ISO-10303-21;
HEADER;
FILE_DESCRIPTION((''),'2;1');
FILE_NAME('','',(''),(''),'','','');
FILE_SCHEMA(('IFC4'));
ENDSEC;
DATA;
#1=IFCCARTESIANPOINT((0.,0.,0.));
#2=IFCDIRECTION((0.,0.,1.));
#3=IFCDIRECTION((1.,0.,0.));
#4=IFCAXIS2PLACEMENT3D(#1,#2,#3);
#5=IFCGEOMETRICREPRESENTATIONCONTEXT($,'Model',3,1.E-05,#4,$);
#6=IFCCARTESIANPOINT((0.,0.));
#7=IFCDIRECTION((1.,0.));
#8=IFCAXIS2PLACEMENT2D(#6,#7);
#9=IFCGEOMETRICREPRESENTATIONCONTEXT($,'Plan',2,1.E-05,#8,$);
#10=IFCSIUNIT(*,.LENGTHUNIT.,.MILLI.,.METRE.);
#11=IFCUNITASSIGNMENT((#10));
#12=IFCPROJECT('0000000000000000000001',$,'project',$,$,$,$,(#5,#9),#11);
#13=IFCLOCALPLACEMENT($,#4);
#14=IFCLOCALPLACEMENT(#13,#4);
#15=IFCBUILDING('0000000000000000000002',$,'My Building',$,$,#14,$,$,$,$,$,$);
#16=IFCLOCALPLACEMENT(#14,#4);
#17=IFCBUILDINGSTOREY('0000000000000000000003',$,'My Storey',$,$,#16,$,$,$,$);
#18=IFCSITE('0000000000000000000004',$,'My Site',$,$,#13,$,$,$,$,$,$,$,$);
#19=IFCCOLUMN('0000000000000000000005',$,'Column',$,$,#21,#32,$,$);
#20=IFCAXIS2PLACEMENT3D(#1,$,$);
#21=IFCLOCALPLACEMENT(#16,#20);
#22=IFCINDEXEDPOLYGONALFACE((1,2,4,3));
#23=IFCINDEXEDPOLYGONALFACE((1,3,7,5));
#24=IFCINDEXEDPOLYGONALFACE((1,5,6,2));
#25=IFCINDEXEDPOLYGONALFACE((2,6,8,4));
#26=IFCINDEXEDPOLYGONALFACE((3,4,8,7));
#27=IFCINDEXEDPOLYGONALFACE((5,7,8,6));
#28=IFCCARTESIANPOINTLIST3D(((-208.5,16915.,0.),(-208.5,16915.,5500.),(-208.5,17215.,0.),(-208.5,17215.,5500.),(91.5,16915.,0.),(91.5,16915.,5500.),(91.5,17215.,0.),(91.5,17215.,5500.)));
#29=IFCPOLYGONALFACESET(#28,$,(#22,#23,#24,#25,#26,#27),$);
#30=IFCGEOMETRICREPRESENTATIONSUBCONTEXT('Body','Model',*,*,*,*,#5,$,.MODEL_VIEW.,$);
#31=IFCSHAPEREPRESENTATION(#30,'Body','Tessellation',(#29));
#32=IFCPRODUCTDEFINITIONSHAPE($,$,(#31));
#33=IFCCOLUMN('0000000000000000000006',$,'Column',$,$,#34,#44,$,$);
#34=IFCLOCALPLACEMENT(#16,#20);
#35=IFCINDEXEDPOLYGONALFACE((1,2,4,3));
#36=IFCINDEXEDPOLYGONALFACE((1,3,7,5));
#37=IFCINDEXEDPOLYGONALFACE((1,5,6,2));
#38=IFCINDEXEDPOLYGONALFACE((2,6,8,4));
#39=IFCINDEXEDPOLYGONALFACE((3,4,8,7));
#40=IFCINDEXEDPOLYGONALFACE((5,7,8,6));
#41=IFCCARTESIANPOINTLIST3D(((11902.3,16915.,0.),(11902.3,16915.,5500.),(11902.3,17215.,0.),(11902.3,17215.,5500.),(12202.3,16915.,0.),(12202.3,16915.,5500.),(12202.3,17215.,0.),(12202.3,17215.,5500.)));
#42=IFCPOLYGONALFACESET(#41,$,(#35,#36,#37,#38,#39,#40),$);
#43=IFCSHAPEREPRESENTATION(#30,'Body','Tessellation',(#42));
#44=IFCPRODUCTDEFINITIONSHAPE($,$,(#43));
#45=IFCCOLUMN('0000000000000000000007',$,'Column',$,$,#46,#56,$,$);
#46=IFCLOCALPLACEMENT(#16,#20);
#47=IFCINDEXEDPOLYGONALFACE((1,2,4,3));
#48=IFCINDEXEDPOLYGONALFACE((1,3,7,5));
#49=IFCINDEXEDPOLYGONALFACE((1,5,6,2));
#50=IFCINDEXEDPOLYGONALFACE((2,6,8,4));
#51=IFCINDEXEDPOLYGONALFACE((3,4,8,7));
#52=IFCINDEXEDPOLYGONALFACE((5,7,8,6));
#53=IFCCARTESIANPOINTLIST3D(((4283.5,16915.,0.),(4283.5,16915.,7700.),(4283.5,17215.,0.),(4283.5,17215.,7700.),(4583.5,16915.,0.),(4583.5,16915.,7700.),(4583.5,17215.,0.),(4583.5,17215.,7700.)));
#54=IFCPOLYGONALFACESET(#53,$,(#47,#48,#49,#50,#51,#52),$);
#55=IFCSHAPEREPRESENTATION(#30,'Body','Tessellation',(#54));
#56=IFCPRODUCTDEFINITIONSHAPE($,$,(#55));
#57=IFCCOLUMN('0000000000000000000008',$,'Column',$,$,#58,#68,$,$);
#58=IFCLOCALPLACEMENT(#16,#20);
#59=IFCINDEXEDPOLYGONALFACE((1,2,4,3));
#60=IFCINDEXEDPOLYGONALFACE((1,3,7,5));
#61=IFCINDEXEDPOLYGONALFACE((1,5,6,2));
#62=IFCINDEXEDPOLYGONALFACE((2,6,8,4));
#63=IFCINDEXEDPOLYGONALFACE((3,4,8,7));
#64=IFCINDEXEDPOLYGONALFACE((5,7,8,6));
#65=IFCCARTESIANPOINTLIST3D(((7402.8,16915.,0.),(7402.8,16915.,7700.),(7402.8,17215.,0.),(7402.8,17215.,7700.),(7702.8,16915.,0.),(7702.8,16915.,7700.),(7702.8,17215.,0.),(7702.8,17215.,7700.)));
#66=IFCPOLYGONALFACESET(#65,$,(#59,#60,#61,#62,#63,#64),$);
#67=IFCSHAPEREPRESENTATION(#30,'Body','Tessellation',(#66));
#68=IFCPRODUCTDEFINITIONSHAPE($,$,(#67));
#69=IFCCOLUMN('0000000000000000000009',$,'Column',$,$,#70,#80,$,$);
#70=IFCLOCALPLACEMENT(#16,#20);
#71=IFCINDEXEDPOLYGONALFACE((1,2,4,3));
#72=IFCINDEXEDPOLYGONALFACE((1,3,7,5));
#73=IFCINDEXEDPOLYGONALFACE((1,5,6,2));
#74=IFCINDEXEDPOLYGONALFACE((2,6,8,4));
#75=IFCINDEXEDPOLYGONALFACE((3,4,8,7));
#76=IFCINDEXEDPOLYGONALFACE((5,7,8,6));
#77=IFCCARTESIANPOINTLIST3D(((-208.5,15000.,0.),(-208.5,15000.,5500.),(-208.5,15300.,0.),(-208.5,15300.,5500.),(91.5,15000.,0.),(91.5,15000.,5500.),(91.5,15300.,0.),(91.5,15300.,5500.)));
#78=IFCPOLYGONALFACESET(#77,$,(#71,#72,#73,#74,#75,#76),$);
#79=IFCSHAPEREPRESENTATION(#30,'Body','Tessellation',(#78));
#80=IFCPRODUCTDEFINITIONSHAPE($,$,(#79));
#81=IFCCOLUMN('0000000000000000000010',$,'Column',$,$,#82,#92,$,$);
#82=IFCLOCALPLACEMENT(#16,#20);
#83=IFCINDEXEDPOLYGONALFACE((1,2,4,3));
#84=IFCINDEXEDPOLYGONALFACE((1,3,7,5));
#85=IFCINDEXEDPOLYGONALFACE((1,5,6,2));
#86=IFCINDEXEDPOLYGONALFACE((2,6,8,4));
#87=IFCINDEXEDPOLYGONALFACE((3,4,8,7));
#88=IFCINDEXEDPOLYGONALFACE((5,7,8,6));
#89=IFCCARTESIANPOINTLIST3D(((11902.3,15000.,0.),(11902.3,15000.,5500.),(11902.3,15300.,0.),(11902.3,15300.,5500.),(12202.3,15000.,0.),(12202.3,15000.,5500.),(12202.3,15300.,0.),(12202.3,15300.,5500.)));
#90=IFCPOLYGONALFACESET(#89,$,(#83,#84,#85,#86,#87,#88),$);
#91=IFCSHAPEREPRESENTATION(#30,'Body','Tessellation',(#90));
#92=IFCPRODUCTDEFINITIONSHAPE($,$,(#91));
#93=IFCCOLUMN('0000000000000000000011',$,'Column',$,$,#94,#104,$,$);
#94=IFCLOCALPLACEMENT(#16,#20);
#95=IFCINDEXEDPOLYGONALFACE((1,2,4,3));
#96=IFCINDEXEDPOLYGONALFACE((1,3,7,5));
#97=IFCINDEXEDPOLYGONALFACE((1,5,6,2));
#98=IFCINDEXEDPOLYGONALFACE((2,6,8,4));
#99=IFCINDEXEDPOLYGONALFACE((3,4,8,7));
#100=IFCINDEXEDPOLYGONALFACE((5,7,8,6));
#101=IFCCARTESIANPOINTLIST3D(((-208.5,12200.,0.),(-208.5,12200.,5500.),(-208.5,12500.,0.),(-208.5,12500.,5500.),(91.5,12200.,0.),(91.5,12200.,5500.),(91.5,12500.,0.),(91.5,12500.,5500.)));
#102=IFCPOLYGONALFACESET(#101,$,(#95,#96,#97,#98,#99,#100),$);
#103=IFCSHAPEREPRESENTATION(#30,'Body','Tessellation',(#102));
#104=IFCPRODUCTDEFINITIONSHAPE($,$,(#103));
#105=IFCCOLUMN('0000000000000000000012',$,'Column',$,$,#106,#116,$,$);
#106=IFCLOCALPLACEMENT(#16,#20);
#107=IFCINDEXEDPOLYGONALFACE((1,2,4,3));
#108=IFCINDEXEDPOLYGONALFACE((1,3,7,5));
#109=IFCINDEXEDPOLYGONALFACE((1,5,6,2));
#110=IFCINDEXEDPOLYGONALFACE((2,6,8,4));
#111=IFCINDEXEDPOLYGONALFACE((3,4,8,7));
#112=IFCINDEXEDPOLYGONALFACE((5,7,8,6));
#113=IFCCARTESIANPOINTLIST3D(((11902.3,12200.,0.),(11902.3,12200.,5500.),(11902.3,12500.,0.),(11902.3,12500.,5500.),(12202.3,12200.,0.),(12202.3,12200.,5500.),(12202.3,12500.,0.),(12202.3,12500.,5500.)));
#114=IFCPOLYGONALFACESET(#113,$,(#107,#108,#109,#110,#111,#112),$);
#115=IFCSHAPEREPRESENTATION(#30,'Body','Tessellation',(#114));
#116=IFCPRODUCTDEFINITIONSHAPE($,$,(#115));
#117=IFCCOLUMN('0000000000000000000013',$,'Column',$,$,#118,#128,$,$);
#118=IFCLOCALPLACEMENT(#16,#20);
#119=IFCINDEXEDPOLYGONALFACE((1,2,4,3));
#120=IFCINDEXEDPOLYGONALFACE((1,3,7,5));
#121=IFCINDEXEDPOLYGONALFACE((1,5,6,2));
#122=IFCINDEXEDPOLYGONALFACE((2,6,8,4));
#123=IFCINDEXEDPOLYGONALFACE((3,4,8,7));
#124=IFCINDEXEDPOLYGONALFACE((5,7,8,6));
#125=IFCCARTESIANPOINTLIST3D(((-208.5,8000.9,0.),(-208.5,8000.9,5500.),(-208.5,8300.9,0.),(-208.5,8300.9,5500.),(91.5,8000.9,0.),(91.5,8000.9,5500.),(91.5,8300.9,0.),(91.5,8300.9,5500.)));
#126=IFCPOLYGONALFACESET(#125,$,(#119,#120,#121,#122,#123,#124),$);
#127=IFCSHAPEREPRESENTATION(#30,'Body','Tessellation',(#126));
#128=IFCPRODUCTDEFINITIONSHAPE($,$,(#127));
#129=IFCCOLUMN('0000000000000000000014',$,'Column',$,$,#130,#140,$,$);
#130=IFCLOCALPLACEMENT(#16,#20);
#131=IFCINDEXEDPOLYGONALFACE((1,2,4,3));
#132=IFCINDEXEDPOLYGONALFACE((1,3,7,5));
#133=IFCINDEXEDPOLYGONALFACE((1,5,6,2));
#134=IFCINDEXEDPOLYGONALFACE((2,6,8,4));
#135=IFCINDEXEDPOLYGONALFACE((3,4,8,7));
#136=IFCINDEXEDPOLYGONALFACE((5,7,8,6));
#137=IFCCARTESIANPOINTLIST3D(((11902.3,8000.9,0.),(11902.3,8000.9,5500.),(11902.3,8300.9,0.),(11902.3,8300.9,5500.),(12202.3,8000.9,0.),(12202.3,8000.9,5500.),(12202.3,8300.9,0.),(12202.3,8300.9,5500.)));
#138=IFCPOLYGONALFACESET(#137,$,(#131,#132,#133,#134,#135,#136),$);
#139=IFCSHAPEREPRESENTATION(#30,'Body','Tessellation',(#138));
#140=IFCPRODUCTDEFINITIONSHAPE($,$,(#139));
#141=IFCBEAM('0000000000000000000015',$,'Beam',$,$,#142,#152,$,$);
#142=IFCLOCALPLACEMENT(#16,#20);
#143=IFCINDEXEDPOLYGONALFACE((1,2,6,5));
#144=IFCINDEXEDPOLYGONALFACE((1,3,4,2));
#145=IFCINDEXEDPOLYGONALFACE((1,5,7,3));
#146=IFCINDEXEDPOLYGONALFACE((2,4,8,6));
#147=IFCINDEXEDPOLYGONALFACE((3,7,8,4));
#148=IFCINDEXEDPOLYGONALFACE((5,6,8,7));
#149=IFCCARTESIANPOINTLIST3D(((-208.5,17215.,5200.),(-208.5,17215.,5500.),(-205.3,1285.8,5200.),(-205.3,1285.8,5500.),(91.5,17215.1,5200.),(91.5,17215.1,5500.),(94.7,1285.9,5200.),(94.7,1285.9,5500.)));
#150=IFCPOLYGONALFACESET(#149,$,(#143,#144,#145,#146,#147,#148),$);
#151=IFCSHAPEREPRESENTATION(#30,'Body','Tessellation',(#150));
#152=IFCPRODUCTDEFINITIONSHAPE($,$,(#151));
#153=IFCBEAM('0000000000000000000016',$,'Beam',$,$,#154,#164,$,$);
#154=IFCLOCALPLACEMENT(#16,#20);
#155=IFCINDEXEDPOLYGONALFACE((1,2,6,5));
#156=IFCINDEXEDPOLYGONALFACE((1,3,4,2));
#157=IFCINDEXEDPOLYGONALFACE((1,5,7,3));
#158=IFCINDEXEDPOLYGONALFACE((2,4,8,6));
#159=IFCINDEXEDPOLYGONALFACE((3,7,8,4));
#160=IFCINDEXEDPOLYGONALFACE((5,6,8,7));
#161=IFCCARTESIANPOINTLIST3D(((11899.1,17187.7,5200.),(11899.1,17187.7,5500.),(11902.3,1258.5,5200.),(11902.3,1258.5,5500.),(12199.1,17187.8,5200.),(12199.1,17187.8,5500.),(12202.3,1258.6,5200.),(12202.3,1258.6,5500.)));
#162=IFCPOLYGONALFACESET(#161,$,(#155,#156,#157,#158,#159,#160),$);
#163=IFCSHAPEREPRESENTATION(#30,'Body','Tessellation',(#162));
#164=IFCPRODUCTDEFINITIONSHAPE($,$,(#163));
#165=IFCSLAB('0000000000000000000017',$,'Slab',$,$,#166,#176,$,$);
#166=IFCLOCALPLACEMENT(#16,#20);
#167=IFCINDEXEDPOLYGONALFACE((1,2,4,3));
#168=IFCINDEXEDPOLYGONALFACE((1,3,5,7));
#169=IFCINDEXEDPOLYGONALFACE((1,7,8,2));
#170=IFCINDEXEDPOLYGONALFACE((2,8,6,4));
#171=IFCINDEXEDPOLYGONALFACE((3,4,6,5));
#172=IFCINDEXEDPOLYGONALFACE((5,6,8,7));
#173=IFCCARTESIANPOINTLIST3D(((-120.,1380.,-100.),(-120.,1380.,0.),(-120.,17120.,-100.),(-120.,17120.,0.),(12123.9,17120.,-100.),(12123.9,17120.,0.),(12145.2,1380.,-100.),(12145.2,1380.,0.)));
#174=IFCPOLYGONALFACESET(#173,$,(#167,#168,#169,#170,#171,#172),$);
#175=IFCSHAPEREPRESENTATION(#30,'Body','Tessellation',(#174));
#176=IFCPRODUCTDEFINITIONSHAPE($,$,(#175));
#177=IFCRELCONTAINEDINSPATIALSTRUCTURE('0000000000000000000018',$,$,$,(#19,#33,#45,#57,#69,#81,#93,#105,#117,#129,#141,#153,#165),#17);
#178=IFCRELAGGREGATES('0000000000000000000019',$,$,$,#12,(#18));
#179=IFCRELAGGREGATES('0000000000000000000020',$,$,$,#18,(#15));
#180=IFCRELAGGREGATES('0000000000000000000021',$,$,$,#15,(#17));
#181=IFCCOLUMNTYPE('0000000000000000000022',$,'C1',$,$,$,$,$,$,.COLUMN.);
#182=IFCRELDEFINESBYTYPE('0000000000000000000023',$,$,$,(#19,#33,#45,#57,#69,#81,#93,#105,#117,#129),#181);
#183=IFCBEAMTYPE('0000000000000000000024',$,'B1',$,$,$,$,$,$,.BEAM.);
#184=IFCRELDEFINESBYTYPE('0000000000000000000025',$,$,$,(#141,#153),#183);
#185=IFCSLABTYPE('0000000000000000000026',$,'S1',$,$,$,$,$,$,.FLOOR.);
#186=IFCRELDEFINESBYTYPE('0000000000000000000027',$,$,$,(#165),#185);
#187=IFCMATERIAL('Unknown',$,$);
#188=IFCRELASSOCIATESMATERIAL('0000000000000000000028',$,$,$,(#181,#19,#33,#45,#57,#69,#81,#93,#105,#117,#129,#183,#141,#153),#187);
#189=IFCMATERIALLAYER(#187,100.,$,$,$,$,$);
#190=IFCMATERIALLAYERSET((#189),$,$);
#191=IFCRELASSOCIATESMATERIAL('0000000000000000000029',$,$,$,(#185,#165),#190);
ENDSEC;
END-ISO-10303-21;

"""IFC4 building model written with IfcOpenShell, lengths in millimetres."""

from ifc_helpers import new_model, si_unit, frame, origin_with_axes, origin_2d_with_axis, place, context, subcontext, project, spatial, indexed_curve, rectangle, outline, extrude, material, layer, layer_set, layer_usage, material_profile, profile_set, profile_usage, type_object, element, save


model = new_model("IFC4")

# Units and contexts
model_context = context("Model", 3, precision=1e-05, world=origin_with_axes())
plan_context = context("Plan", 2, precision=1e-05, world=origin_2d_with_axis())
body_context_1 = subcontext(model_context, "Body", "Model", "MODEL_VIEW")
ifc_project = project(units=[si_unit("LENGTHUNIT", "METRE", prefix="MILLI")], contexts=[model_context, plan_context])

# Site, building, storey
site_placement = place(None, origin_with_axes())
site = spatial("IfcSite", under=ifc_project, at=site_placement, Name="My Site")
building_placement = place(site_placement, origin_with_axes())
building = spatial("IfcBuilding", under=site, at=building_placement, Name="My Building")
storey_placement = place(building_placement, origin_with_axes())
storey = spatial("IfcBuildingStorey", under=building, at=storey_placement, Name="My Storey")

# Columns
ifc_material = material(Name="Unknown")
ifc_material_profile_1 = material_profile(ifc_material, rectangle(XDim=300.0, YDim=300.0))
ifc_profile_set_1 = profile_set([ifc_material_profile_1])
ifc_profile_usage_1 = profile_usage(ifc_profile_set_1, cardinal=5)
column_type = type_object("IfcColumnType", Name="C1", PredefinedType="COLUMN", material=ifc_profile_set_1)
column_1_placement = place(storey_placement, frame((-58.5, 17065.0, 0.0), z_axis=(0.0, 0.0, 1.0), x_axis=(1.0, 0.0, 0.0)))
element("IfcColumn", 1, at=column_1_placement, inside=storey, type_object=column_type, material=ifc_profile_usage_1, Name="Column", context=body_context_1, shape_type="SweptSolid", body=[
    extrude(rectangle(XDim=300.0, YDim=300.0), origin_with_axes(), (0.0, 0.0, 1.0), 5500.0),
])
ifc_profile_usage_2 = profile_usage(ifc_profile_set_1, cardinal=5)
column_2_placement = place(storey_placement, frame((12052.3, 17065.0, 0.0), z_axis=(0.0, 0.0, 1.0), x_axis=(1.0, 0.0, 0.0)))
element("IfcColumn", 2, at=column_2_placement, inside=storey, type_object=column_type, material=ifc_profile_usage_2, Name="Column", context=body_context_1, shape_type="SweptSolid", body=[
    extrude(rectangle(XDim=300.0, YDim=300.0), origin_with_axes(), (0.0, 0.0, 1.0), 5500.0),
])
ifc_profile_usage_3 = profile_usage(ifc_profile_set_1, cardinal=5)
column_3_placement = place(storey_placement, frame((4433.5, 17065.0, 0.0), z_axis=(0.0, 0.0, 1.0), x_axis=(1.0, 0.0, 0.0)))
element("IfcColumn", 3, at=column_3_placement, inside=storey, type_object=column_type, material=ifc_profile_usage_3, Name="Column", context=body_context_1, shape_type="SweptSolid", body=[
    extrude(rectangle(XDim=300.0, YDim=300.0), origin_with_axes(), (0.0, 0.0, 1.0), 7700.0),
])
ifc_profile_usage_4 = profile_usage(ifc_profile_set_1, cardinal=5)
column_4_placement = place(storey_placement, frame((7552.8, 17065.0, 0.0), z_axis=(0.0, 0.0, 1.0), x_axis=(1.0, 0.0, 0.0)))
element("IfcColumn", 4, at=column_4_placement, inside=storey, type_object=column_type, material=ifc_profile_usage_4, Name="Column", context=body_context_1, shape_type="SweptSolid", body=[
    extrude(rectangle(XDim=300.0, YDim=300.0), origin_with_axes(), (0.0, 0.0, 1.0), 7700.0),
])
ifc_profile_usage_5 = profile_usage(ifc_profile_set_1, cardinal=5)
column_5_placement = place(storey_placement, frame((-58.5, 15150.0, 0.0), z_axis=(0.0, 0.0, 1.0), x_axis=(1.0, 0.0, 0.0)))
element("IfcColumn", 5, at=column_5_placement, inside=storey, type_object=column_type, material=ifc_profile_usage_5, Name="Column", context=body_context_1, shape_type="SweptSolid", body=[
    extrude(rectangle(XDim=300.0, YDim=300.0), origin_with_axes(), (0.0, 0.0, 1.0), 5500.0),
])
ifc_profile_usage_6 = profile_usage(ifc_profile_set_1, cardinal=5)
column_6_placement = place(storey_placement, frame((12052.3, 15150.0, 0.0), z_axis=(0.0, 0.0, 1.0), x_axis=(1.0, 0.0, 0.0)))
element("IfcColumn", 6, at=column_6_placement, inside=storey, type_object=column_type, material=ifc_profile_usage_6, Name="Column", context=body_context_1, shape_type="SweptSolid", body=[
    extrude(rectangle(XDim=300.0, YDim=300.0), origin_with_axes(), (0.0, 0.0, 1.0), 5500.0),
])
ifc_profile_usage_7 = profile_usage(ifc_profile_set_1, cardinal=5)
column_7_placement = place(storey_placement, frame((-58.5, 12350.0, 0.0), z_axis=(0.0, 0.0, 1.0), x_axis=(1.0, 0.0, 0.0)))
element("IfcColumn", 7, at=column_7_placement, inside=storey, type_object=column_type, material=ifc_profile_usage_7, Name="Column", context=body_context_1, shape_type="SweptSolid", body=[
    extrude(rectangle(XDim=300.0, YDim=300.0), origin_with_axes(), (0.0, 0.0, 1.0), 5500.0),
])
ifc_profile_usage_8 = profile_usage(ifc_profile_set_1, cardinal=5)
column_8_placement = place(storey_placement, frame((12052.3, 12350.0, 0.0), z_axis=(0.0, 0.0, 1.0), x_axis=(1.0, 0.0, 0.0)))
element("IfcColumn", 8, at=column_8_placement, inside=storey, type_object=column_type, material=ifc_profile_usage_8, Name="Column", context=body_context_1, shape_type="SweptSolid", body=[
    extrude(rectangle(XDim=300.0, YDim=300.0), origin_with_axes(), (0.0, 0.0, 1.0), 5500.0),
])
ifc_profile_usage_9 = profile_usage(ifc_profile_set_1, cardinal=5)
column_9_placement = place(storey_placement, frame((-58.5, 8150.9, 0.0), z_axis=(0.0, 0.0, 1.0), x_axis=(1.0, 0.0, 0.0)))
element("IfcColumn", 9, at=column_9_placement, inside=storey, type_object=column_type, material=ifc_profile_usage_9, Name="Column", context=body_context_1, shape_type="SweptSolid", body=[
    extrude(rectangle(XDim=300.0, YDim=300.0), origin_with_axes(), (0.0, 0.0, 1.0), 5500.0),
])
ifc_profile_usage_10 = profile_usage(ifc_profile_set_1, cardinal=5)
column_10_placement = place(storey_placement, frame((12052.3, 8150.9, 0.0), z_axis=(0.0, 0.0, 1.0), x_axis=(1.0, 0.0, 0.0)))
element("IfcColumn", 10, at=column_10_placement, inside=storey, type_object=column_type, material=ifc_profile_usage_10, Name="Column", context=body_context_1, shape_type="SweptSolid", body=[
    extrude(rectangle(XDim=300.0, YDim=300.0), origin_with_axes(), (0.0, 0.0, 1.0), 5500.0),
])

# Beams
ifc_material_profile_2 = material_profile(ifc_material, rectangle(XDim=300.0, YDim=300.0))
ifc_profile_set_2 = profile_set([ifc_material_profile_2])
ifc_profile_usage_11 = profile_usage(ifc_profile_set_2, cardinal=9)
beam_type = type_object("IfcBeamType", Name="B1", PredefinedType="BEAM", material=ifc_profile_set_2)
beam_1_placement = place(storey_placement, frame((-208.5, 17215.0, 5500.0), z_axis=(0.000199, -1.0, 0.0), x_axis=(1.0, 0.000199, 0.0)))
element("IfcBeam", 11, at=beam_1_placement, inside=storey, type_object=beam_type, material=ifc_profile_usage_11, Name="Beam", context=body_context_1, shape_type="SweptSolid", body=[
    extrude(rectangle(XDim=300.0, YDim=300.0), frame((150.0, -150.0, 0.0), z_axis=(0.0, 0.0, 1.0), x_axis=(1.0, 0.0, 0.0)), (0.0, 0.0, 1.0), 15929.2),
])
ifc_profile_usage_12 = profile_usage(ifc_profile_set_2, cardinal=9)
beam_2_placement = place(storey_placement, frame((11899.1, 17187.7, 5500.0), z_axis=(0.000199, -1.0, 0.0), x_axis=(1.0, 0.000199, 0.0)))
element("IfcBeam", 12, at=beam_2_placement, inside=storey, type_object=beam_type, material=ifc_profile_usage_12, Name="Beam", context=body_context_1, shape_type="SweptSolid", body=[
    extrude(rectangle(XDim=300.0, YDim=300.0), frame((150.0, -150.0, 0.0), z_axis=(0.0, 0.0, 1.0), x_axis=(1.0, 0.0, 0.0)), (0.0, 0.0, 1.0), 15929.2),
])

# Slab
ifc_layer_1 = layer(ifc_material, 100.0)
ifc_layer_set_1 = layer_set([ifc_layer_1])
ifc_layer_usage_1 = layer_usage(ifc_layer_set_1, "AXIS3", "POSITIVE", -100.0)
slab_type_1 = type_object("IfcSlabType", Name="S1", PredefinedType="FLOOR", material=ifc_layer_set_1)
slab_1_placement = place(storey_placement, frame((12123.9, 17120.0, 0.0), z_axis=(0.0, 0.0, 1.0), x_axis=(1.0, 0.0, 0.0)))
element("IfcSlab", 13, at=slab_1_placement, inside=storey, type_object=slab_type_1, material=ifc_layer_usage_1, Name="Slab", context=body_context_1, shape_type="SweptSolid", body=[
    extrude(outline(indexed_curve([(0.0, 0.0), (21.3, -15740.0), (-12243.9, -15740.0), (-12243.9, 0.0), (0.0, 0.0)])), frame((0.0, 0.0, -100.0), z_axis=(0.0, 0.0, 1.0), x_axis=(1.0, 0.0, 0.0)), (0.0, 0.0, 1.0), 100.0),
])

save(model, "model.ifc")
